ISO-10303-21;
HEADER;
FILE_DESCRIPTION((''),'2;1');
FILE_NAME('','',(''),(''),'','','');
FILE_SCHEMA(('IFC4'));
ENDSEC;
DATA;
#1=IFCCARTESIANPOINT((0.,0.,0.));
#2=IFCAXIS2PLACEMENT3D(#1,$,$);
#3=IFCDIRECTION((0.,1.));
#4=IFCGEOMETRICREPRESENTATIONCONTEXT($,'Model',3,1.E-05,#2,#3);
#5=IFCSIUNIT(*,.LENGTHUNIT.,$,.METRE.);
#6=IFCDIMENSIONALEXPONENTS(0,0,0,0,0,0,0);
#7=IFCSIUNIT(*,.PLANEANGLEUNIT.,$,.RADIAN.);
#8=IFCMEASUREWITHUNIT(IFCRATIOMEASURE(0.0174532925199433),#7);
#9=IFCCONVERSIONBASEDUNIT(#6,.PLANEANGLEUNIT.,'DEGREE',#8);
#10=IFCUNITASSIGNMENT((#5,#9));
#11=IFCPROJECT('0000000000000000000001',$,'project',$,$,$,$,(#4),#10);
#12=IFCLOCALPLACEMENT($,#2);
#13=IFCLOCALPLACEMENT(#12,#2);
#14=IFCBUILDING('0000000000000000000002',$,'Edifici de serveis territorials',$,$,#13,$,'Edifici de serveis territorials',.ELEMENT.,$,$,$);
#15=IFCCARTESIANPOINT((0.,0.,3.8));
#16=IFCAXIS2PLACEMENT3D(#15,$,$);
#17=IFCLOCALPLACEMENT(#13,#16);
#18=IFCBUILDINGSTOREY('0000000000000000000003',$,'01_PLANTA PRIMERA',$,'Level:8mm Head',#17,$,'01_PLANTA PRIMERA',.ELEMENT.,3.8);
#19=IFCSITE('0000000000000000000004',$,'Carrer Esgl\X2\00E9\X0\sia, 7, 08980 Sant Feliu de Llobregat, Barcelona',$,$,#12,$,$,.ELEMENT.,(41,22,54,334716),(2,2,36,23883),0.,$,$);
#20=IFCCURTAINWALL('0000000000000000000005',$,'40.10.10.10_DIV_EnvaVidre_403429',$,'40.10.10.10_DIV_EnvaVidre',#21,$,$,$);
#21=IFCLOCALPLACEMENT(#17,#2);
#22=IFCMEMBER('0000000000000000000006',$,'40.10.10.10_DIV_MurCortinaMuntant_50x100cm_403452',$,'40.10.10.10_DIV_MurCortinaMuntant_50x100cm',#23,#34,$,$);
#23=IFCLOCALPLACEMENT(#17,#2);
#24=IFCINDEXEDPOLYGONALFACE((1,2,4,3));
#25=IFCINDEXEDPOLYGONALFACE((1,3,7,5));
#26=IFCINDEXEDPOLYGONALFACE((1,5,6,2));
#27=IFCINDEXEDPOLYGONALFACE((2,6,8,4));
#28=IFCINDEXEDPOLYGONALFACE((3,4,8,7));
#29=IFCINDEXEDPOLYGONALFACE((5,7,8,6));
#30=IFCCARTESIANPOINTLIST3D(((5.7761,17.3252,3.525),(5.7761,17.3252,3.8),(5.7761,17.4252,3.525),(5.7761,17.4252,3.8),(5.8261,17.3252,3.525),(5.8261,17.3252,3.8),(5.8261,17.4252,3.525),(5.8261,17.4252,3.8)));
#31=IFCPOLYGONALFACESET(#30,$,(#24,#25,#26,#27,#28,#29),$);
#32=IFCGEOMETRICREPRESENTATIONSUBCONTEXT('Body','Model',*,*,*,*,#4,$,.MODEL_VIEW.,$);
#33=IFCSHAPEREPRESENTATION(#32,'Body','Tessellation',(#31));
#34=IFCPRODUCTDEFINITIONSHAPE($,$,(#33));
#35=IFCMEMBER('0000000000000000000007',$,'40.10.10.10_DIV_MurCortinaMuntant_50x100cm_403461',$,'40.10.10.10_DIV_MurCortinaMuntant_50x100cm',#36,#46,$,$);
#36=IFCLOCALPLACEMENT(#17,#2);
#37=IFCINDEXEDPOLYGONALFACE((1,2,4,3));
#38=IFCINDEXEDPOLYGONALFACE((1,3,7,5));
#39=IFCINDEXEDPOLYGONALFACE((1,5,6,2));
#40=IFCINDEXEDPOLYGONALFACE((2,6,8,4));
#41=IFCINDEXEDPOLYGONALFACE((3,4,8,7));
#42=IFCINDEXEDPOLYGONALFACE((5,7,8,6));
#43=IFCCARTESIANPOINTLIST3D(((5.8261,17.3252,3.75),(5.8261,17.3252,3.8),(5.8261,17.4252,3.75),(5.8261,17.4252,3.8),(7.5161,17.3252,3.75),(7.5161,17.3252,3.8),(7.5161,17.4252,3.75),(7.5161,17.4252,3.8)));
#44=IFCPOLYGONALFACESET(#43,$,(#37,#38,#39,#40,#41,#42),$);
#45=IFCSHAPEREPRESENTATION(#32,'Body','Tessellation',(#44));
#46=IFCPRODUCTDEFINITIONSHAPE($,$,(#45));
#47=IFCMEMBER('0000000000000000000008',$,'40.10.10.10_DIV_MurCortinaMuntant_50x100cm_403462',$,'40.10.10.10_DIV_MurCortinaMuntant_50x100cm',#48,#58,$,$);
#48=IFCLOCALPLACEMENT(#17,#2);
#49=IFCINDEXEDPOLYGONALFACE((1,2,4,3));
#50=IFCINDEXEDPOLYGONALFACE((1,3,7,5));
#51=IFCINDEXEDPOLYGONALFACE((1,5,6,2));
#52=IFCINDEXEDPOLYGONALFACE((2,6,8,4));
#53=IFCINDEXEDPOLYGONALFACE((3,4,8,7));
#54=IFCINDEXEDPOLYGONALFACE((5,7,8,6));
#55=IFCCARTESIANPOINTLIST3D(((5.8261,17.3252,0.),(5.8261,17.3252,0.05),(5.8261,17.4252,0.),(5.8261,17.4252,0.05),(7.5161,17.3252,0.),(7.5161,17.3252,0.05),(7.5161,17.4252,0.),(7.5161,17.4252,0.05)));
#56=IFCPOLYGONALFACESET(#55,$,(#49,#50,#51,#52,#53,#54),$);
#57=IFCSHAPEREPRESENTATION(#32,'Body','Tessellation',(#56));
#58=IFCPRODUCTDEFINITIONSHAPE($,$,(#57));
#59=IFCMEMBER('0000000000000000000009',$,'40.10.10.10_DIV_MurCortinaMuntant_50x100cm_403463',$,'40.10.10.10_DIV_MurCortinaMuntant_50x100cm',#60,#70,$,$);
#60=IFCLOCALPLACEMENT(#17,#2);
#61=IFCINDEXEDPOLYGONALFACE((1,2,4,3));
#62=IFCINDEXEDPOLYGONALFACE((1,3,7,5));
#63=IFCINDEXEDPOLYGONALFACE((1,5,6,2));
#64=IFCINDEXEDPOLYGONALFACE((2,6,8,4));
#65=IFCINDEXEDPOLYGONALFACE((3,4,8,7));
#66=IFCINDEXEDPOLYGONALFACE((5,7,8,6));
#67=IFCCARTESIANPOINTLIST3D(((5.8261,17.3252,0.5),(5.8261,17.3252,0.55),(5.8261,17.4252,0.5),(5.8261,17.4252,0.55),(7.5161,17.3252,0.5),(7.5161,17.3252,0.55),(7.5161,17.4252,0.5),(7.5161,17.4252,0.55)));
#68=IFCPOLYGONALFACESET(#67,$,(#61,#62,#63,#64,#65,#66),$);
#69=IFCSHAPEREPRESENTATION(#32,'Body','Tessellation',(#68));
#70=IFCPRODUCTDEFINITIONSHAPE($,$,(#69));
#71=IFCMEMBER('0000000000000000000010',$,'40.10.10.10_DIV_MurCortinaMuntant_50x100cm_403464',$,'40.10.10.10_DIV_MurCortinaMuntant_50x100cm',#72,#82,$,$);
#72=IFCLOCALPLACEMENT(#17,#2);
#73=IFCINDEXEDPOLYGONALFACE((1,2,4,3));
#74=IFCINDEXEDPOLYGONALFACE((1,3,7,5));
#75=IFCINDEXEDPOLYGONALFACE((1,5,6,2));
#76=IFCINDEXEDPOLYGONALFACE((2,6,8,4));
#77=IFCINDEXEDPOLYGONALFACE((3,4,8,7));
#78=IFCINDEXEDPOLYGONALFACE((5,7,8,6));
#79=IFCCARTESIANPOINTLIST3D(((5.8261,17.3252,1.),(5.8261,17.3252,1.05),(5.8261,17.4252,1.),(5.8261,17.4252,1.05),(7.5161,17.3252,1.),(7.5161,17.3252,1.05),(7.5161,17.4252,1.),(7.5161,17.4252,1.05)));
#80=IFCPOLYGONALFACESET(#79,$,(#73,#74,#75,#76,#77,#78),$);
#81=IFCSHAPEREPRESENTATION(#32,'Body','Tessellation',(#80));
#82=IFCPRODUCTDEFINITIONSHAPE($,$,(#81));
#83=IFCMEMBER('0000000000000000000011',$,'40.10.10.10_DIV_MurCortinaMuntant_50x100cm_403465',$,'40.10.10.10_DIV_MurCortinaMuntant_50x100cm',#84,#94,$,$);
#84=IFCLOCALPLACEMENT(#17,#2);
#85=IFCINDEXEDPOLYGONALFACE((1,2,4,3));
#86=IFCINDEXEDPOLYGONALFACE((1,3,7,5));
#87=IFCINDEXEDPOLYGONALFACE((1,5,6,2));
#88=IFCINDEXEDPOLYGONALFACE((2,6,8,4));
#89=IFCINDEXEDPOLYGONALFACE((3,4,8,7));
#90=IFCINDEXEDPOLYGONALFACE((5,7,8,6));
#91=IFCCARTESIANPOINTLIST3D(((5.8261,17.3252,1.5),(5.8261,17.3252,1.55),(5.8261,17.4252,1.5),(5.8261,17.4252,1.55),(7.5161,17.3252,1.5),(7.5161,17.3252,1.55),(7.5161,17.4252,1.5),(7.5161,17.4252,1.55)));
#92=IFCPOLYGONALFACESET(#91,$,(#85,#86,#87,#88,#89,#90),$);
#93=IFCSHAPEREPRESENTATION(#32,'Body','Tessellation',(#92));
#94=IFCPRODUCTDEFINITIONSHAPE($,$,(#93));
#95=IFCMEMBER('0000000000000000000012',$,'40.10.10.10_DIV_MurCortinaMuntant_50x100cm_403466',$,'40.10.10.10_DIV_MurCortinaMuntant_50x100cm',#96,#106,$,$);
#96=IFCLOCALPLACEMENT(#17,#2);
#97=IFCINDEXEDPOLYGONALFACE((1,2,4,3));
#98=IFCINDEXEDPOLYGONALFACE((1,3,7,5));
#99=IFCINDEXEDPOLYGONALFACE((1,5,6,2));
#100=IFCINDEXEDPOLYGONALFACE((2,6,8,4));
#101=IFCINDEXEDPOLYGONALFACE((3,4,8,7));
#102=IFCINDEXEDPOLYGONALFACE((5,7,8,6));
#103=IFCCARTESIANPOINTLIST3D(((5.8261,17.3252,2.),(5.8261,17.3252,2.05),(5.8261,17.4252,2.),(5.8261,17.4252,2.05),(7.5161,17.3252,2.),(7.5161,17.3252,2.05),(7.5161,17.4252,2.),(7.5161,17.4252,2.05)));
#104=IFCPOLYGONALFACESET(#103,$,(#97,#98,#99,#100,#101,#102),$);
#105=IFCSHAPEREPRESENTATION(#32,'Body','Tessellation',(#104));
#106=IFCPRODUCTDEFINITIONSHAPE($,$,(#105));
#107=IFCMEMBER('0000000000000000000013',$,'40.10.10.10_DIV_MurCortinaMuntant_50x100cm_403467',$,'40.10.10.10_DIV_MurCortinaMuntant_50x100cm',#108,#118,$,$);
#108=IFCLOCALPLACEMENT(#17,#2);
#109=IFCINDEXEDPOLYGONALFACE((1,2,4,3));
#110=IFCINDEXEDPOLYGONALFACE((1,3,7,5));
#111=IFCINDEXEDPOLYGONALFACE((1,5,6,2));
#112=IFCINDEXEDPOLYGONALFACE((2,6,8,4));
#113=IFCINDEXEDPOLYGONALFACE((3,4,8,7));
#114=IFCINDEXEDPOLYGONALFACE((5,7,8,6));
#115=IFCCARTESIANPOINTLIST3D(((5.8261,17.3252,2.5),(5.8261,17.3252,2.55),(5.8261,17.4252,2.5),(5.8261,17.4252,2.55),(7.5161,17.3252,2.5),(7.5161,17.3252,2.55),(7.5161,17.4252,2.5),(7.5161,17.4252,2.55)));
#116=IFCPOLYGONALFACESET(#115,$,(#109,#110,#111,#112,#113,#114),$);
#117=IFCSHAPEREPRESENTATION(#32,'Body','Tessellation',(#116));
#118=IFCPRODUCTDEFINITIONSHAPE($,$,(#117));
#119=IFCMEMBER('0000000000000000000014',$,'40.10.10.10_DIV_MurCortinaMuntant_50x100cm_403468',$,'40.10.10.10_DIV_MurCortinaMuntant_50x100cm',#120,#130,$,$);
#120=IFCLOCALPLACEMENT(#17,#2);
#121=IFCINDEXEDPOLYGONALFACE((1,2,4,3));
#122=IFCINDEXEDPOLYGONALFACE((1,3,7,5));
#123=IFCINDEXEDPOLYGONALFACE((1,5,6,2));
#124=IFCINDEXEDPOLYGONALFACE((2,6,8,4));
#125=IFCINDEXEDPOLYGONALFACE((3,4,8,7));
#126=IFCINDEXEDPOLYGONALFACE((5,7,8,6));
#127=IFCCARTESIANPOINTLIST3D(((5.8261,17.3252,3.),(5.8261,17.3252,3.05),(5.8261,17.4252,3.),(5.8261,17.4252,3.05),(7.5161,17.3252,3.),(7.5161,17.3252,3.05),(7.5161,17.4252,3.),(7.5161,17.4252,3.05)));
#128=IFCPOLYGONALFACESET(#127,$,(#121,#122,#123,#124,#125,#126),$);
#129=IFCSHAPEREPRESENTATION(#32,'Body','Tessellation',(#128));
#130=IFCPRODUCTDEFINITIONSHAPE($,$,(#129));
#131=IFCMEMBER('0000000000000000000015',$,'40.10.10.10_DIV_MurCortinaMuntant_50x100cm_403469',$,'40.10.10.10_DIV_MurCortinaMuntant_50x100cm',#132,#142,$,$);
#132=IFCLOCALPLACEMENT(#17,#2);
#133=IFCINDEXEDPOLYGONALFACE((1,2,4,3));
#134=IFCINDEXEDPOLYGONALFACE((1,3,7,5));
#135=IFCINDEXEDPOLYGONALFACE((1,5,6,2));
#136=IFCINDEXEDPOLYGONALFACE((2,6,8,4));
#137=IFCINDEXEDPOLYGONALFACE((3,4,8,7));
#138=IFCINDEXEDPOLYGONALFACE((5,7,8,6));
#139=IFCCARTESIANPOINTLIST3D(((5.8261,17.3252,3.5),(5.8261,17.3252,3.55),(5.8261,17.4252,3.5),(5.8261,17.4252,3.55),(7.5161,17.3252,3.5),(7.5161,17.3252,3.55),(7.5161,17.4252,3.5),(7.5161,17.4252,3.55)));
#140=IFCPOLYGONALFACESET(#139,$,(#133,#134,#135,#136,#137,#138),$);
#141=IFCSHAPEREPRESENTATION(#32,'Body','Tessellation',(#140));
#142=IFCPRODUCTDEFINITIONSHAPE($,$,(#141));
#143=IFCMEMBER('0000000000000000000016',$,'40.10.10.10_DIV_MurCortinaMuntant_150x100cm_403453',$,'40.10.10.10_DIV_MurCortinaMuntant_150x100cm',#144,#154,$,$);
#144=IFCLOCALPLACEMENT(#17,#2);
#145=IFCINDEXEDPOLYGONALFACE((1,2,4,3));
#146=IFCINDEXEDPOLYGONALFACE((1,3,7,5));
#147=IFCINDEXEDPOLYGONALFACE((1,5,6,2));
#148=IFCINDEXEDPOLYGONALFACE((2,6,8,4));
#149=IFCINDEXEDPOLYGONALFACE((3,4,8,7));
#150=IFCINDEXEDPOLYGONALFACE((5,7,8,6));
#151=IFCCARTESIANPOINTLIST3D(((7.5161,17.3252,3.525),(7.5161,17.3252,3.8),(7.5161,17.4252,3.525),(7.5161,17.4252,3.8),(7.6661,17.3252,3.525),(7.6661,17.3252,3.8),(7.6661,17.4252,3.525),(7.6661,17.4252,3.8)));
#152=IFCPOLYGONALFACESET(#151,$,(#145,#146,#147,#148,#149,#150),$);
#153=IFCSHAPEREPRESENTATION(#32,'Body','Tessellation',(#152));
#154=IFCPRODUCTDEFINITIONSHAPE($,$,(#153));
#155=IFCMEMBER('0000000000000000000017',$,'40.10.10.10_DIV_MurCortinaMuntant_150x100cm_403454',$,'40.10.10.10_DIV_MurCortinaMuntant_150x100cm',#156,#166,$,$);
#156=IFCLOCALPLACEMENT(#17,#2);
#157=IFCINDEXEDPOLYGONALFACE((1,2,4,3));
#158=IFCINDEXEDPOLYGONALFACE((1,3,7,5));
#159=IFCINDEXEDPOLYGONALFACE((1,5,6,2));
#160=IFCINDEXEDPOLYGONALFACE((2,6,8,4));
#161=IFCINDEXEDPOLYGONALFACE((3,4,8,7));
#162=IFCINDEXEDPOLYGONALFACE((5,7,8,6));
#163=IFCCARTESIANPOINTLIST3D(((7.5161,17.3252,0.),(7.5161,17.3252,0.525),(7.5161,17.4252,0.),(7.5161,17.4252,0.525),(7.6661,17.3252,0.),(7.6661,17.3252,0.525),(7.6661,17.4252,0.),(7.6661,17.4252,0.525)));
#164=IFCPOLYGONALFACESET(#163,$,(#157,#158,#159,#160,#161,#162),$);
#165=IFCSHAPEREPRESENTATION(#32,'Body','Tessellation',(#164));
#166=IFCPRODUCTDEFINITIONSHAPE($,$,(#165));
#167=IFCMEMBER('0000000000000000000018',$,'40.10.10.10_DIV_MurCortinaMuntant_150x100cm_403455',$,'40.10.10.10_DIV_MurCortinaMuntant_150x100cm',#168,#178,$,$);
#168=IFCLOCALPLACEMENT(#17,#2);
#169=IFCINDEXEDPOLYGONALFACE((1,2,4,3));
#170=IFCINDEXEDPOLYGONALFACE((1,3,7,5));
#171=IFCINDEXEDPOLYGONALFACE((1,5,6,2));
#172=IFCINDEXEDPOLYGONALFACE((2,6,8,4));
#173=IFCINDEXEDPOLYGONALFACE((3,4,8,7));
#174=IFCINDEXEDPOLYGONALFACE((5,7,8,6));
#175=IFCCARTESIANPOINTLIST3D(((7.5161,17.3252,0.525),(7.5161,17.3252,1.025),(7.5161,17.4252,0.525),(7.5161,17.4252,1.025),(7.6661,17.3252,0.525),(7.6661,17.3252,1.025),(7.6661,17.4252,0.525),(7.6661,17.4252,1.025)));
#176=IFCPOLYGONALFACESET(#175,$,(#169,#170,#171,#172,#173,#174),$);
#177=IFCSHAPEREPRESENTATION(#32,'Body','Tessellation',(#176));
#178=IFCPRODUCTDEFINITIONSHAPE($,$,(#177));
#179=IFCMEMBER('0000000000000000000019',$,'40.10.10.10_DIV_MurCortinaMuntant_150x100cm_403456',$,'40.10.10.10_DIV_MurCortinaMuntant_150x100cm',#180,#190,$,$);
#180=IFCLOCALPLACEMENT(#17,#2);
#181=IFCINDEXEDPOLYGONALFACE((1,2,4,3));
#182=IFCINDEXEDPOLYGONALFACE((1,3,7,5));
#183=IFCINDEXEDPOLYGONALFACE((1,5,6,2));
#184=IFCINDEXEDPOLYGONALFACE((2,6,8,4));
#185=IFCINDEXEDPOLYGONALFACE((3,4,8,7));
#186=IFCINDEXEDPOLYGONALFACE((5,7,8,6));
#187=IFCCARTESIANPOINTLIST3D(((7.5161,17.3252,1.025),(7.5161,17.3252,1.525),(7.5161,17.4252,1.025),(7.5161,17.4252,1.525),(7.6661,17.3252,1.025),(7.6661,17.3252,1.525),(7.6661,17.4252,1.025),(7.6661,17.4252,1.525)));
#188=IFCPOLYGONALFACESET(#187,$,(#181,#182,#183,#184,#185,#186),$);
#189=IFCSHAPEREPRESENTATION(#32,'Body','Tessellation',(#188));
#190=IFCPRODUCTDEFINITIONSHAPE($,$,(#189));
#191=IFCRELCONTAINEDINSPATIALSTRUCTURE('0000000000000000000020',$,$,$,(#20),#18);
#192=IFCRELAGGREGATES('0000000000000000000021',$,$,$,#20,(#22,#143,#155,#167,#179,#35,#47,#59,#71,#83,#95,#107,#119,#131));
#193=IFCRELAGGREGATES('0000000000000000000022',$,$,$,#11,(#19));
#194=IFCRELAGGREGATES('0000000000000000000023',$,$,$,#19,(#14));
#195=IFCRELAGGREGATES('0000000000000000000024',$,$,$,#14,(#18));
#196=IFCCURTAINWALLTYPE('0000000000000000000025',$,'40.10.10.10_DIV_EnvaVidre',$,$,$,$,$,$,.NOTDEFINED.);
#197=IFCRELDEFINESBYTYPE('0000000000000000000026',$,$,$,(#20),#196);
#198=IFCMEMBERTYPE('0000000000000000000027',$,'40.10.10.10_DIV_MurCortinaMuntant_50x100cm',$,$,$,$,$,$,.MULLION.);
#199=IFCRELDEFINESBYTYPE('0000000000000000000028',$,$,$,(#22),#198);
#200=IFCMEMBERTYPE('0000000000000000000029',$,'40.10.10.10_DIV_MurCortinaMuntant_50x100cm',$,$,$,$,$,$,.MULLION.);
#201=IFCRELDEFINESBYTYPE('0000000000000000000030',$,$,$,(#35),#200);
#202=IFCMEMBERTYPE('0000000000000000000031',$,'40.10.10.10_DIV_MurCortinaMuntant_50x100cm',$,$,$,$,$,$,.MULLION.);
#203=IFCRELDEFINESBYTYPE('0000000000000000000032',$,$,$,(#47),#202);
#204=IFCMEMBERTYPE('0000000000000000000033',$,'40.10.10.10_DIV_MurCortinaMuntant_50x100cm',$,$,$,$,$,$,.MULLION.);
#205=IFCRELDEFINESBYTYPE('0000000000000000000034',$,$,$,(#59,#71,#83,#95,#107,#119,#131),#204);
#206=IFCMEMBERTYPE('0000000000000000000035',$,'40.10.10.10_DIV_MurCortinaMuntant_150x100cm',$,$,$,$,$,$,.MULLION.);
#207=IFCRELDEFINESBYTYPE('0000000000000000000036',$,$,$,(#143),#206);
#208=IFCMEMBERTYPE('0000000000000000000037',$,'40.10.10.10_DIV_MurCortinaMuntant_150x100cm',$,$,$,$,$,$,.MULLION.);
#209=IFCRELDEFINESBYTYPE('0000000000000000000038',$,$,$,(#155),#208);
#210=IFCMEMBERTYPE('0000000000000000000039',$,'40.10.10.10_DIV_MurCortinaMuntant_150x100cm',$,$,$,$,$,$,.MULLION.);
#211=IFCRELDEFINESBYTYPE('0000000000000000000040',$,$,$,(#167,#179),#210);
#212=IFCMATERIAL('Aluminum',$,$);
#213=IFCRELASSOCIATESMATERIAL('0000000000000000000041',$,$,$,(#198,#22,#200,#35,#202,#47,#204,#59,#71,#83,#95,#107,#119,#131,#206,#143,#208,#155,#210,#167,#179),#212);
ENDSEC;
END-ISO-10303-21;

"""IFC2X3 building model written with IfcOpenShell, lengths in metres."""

from ifc_helpers import new_model, entity, si_unit, converted_unit, direction, frame, origin, origin_2d_with_axis, place, context, subcontext, project, spatial, rectangle, extrude, source, transform, mapped, material, type_object, type_shapes, element, aggregate, save


model = new_model("IFC2X3")

# Units and contexts
model_context = context("Model", 3, precision=1e-05, world=origin(), true_north=direction((0.0, 1.0)))
body_context = subcontext(model_context, "Body", "Model", "MODEL_VIEW")
ifc_project = project(units=[si_unit("LENGTHUNIT", "METRE"), converted_unit("PLANEANGLEUNIT", "DEGREE", entity("IfcRatioMeasure", 0.0174532925199433), si_unit("PLANEANGLEUNIT", "RADIAN"), dimensions=[0, 0, 0, 0, 0, 0, 0])], contexts=[model_context])

# Site, building, storey
site_placement = place(None, origin())
site = spatial("IfcSite", under=ifc_project, at=site_placement, Name="Carrer Església, 7, 08980 Sant Feliu de Llobregat, Barcelona", CompositionType="ELEMENT", RefLatitude=(41, 22, 54, 334716), RefLongitude=(2, 2, 36, 23883), RefElevation=0.0)
building_placement = place(site_placement, origin())
building = spatial("IfcBuilding", under=site, at=building_placement, Name="Edifici de serveis territorials", LongName="Edifici de serveis territorials", CompositionType="ELEMENT")
storey_placement = place(building_placement, frame((0.0, 0.0, 3.8)))
storey = spatial("IfcBuildingStorey", under=building, at=storey_placement, Name="01_PLANTA PRIMERA", ObjectType="Level:8mm Head", LongName="01_PLANTA PRIMERA", CompositionType="ELEMENT", Elevation=3.8)

# Curtain wall
curtain_wall_type = type_object("IfcCurtainWallType", Name="40.10.10.10_DIV_EnvaVidre", PredefinedType="NOTDEFINED")
ifc_material_1 = material(Name="Aluminum")
curtain_wall_1_placement = place(storey_placement, frame((0.0, 0.0, -3.8)))
curtain_wall_1 = element("IfcCurtainWall", 1, at=curtain_wall_1_placement, inside=storey, type_object=curtain_wall_type, Name="40.10.10.10_DIV_EnvaVidre_403429", ObjectType="40.10.10.10_DIV_EnvaVidre")

# Members
member_type_1 = type_object("IfcMemberType", Name="40.10.10.10_DIV_MurCortinaMuntant_50x100cm", PredefinedType="MULLION", material=ifc_material_1)
shared_shape_1 = source(origin(), body_context, "Body", "SweptSolid", [
    extrude(rectangle(XDim=0.1, YDim=0.05, at=origin_2d_with_axis()), frame((-0.025, 0.0, -0.275), z_axis=(0.0, 0.0, 1.0), x_axis=(0.0, -1.0, 0.0)), (0.0, 0.0, 1.0), 0.275),
])
type_shapes(member_type_1, [shared_shape_1])
member_1_placement = place(storey_placement, frame((5.7761, 17.3752, 3.525), z_axis=(0.0, 0.0, -1.0), x_axis=(-1.0, 0.0, 0.0)))
member_1 = element("IfcMember", 2, at=member_1_placement, type_object=member_type_1, material=ifc_material_1, Name="40.10.10.10_DIV_MurCortinaMuntant_50x100cm_403452", ObjectType="40.10.10.10_DIV_MurCortinaMuntant_50x100cm", context=body_context, shape_type="MappedRepresentation", body=[
    mapped(shared_shape_1, transform((0.0, 0.0, 0.0), scale=1.0)),
])
member_type_2 = type_object("IfcMemberType", Name="40.10.10.10_DIV_MurCortinaMuntant_50x100cm", PredefinedType="MULLION", material=ifc_material_1)
shared_shape_2 = source(origin(), body_context, "Body", "SweptSolid", [
    extrude(rectangle(XDim=0.1, YDim=0.05, at=origin_2d_with_axis()), frame((-0.025, 0.0, -1.69), z_axis=(0.0, 0.0, 1.0), x_axis=(0.0, -1.0, 0.0)), (0.0, 0.0, 1.0), 1.69),
])
type_shapes(member_type_2, [shared_shape_2])
member_2_placement = place(storey_placement, frame((5.8261, 17.3752, 3.8), z_axis=(-1.0, 0.0, 0.0), x_axis=(0.0, 0.0, 1.0)))
member_2 = element("IfcMember", 3, at=member_2_placement, type_object=member_type_2, material=ifc_material_1, Name="40.10.10.10_DIV_MurCortinaMuntant_50x100cm_403461", ObjectType="40.10.10.10_DIV_MurCortinaMuntant_50x100cm", context=body_context, shape_type="MappedRepresentation", body=[
    mapped(shared_shape_2, transform((0.0, 0.0, 0.0), scale=1.0)),
])
member_type_3 = type_object("IfcMemberType", Name="40.10.10.10_DIV_MurCortinaMuntant_50x100cm", PredefinedType="MULLION", material=ifc_material_1)
shared_shape_3 = source(origin(), body_context, "Body", "SweptSolid", [
    extrude(rectangle(XDim=0.1, YDim=0.05, at=origin_2d_with_axis()), frame((-0.025, 0.0, -1.69), z_axis=(0.0, 0.0, 1.0), x_axis=(0.0, -1.0, 0.0)), (0.0, 0.0, 1.0), 1.69),
])
type_shapes(member_type_3, [shared_shape_3])
member_3_placement = place(storey_placement, frame((7.5161, 17.3752, 0.0), z_axis=(1.0, 0.0, 0.0), x_axis=(0.0, 0.0, -1.0)))
member_3 = element("IfcMember", 4, at=member_3_placement, type_object=member_type_3, material=ifc_material_1, Name="40.10.10.10_DIV_MurCortinaMuntant_50x100cm_403462", ObjectType="40.10.10.10_DIV_MurCortinaMuntant_50x100cm", context=body_context, shape_type="MappedRepresentation", body=[
    mapped(shared_shape_3, transform((0.0, 0.0, 0.0), scale=1.0)),
])
member_type_4 = type_object("IfcMemberType", Name="40.10.10.10_DIV_MurCortinaMuntant_50x100cm", PredefinedType="MULLION", material=ifc_material_1)
shared_shape_4 = source(origin(), body_context, "Body", "SweptSolid", [
    extrude(rectangle(XDim=0.1, YDim=0.05, at=origin_2d_with_axis()), frame((0.0, 0.0, -1.69), z_axis=(0.0, 0.0, 1.0), x_axis=(0.0, -1.0, 0.0)), (0.0, 0.0, 1.0), 1.69),
])
type_shapes(member_type_4, [shared_shape_4])
member_4_placement = place(storey_placement, frame((5.8261, 17.3752, 0.525), z_axis=(-1.0, 0.0, 0.0), x_axis=(0.0, 0.0, 1.0)))
member_4 = element("IfcMember", 5, at=member_4_placement, type_object=member_type_4, material=ifc_material_1, Name="40.10.10.10_DIV_MurCortinaMuntant_50x100cm_403463", ObjectType="40.10.10.10_DIV_MurCortinaMuntant_50x100cm", context=body_context, shape_type="MappedRepresentation", body=[
    mapped(shared_shape_4, transform((0.0, 0.0, 0.0), scale=1.0)),
])
member_5_placement = place(storey_placement, frame((5.8261, 17.3752, 1.025), z_axis=(-1.0, 0.0, 0.0), x_axis=(0.0, 0.0, 1.0)))
member_5 = element("IfcMember", 6, at=member_5_placement, type_object=member_type_4, material=ifc_material_1, Name="40.10.10.10_DIV_MurCortinaMuntant_50x100cm_403464", ObjectType="40.10.10.10_DIV_MurCortinaMuntant_50x100cm", context=body_context, shape_type="MappedRepresentation", body=[
    mapped(shared_shape_4, transform((0.0, 0.0, 0.0), scale=1.0)),
])
member_6_placement = place(storey_placement, frame((5.8261, 17.3752, 1.525), z_axis=(-1.0, 0.0, 0.0), x_axis=(0.0, 0.0, 1.0)))
member_6 = element("IfcMember", 7, at=member_6_placement, type_object=member_type_4, material=ifc_material_1, Name="40.10.10.10_DIV_MurCortinaMuntant_50x100cm_403465", ObjectType="40.10.10.10_DIV_MurCortinaMuntant_50x100cm", context=body_context, shape_type="MappedRepresentation", body=[
    mapped(shared_shape_4, transform((0.0, 0.0, 0.0), scale=1.0)),
])
member_7_placement = place(storey_placement, frame((5.8261, 17.3752, 2.025), z_axis=(-1.0, 0.0, 0.0), x_axis=(0.0, 0.0, 1.0)))
member_7 = element("IfcMember", 8, at=member_7_placement, type_object=member_type_4, material=ifc_material_1, Name="40.10.10.10_DIV_MurCortinaMuntant_50x100cm_403466", ObjectType="40.10.10.10_DIV_MurCortinaMuntant_50x100cm", context=body_context, shape_type="MappedRepresentation", body=[
    mapped(shared_shape_4, transform((0.0, 0.0, 0.0), scale=1.0)),
])
member_8_placement = place(storey_placement, frame((5.8261, 17.3752, 2.525), z_axis=(-1.0, 0.0, 0.0), x_axis=(0.0, 0.0, 1.0)))
member_8 = element("IfcMember", 9, at=member_8_placement, type_object=member_type_4, material=ifc_material_1, Name="40.10.10.10_DIV_MurCortinaMuntant_50x100cm_403467", ObjectType="40.10.10.10_DIV_MurCortinaMuntant_50x100cm", context=body_context, shape_type="MappedRepresentation", body=[
    mapped(shared_shape_4, transform((0.0, 0.0, 0.0), scale=1.0)),
])
member_9_placement = place(storey_placement, frame((5.8261, 17.3752, 3.025), z_axis=(-1.0, 0.0, 0.0), x_axis=(0.0, 0.0, 1.0)))
member_9 = element("IfcMember", 10, at=member_9_placement, type_object=member_type_4, material=ifc_material_1, Name="40.10.10.10_DIV_MurCortinaMuntant_50x100cm_403468", ObjectType="40.10.10.10_DIV_MurCortinaMuntant_50x100cm", context=body_context, shape_type="MappedRepresentation", body=[
    mapped(shared_shape_4, transform((0.0, 0.0, 0.0), scale=1.0)),
])
member_10_placement = place(storey_placement, frame((5.8261, 17.3752, 3.525), z_axis=(-1.0, 0.0, 0.0), x_axis=(0.0, 0.0, 1.0)))
member_10 = element("IfcMember", 11, at=member_10_placement, type_object=member_type_4, material=ifc_material_1, Name="40.10.10.10_DIV_MurCortinaMuntant_50x100cm_403469", ObjectType="40.10.10.10_DIV_MurCortinaMuntant_50x100cm", context=body_context, shape_type="MappedRepresentation", body=[
    mapped(shared_shape_4, transform((0.0, 0.0, 0.0), scale=1.0)),
])
member_type_5 = type_object("IfcMemberType", Name="40.10.10.10_DIV_MurCortinaMuntant_150x100cm", PredefinedType="MULLION", material=ifc_material_1)
shared_shape_5 = source(origin(), body_context, "Body", "SweptSolid", [
    extrude(rectangle(XDim=0.1, YDim=0.15, at=origin_2d_with_axis()), frame((-0.075, 0.0, -0.275), z_axis=(0.0, 0.0, 1.0), x_axis=(0.0, -1.0, 0.0)), (0.0, 0.0, 1.0), 0.275),
])
type_shapes(member_type_5, [shared_shape_5])
member_11_placement = place(storey_placement, frame((7.6661, 17.3752, 3.8)))
member_11 = element("IfcMember", 12, at=member_11_placement, type_object=member_type_5, material=ifc_material_1, Name="40.10.10.10_DIV_MurCortinaMuntant_150x100cm_403453", ObjectType="40.10.10.10_DIV_MurCortinaMuntant_150x100cm", context=body_context, shape_type="MappedRepresentation", body=[
    mapped(shared_shape_5, transform((0.0, 0.0, 0.0), scale=1.0)),
])
member_type_6 = type_object("IfcMemberType", Name="40.10.10.10_DIV_MurCortinaMuntant_150x100cm", PredefinedType="MULLION", material=ifc_material_1)
shared_shape_6 = source(origin(), body_context, "Body", "SweptSolid", [
    extrude(rectangle(XDim=0.1, YDim=0.15, at=origin_2d_with_axis()), frame((-0.075, 0.0, -0.525), z_axis=(0.0, 0.0, 1.0), x_axis=(0.0, -1.0, 0.0)), (0.0, 0.0, 1.0), 0.525),
])
type_shapes(member_type_6, [shared_shape_6])
member_12_placement = place(storey_placement, frame((7.6661, 17.3752, 0.525)))
member_12 = element("IfcMember", 13, at=member_12_placement, type_object=member_type_6, material=ifc_material_1, Name="40.10.10.10_DIV_MurCortinaMuntant_150x100cm_403454", ObjectType="40.10.10.10_DIV_MurCortinaMuntant_150x100cm", context=body_context, shape_type="MappedRepresentation", body=[
    mapped(shared_shape_6, transform((0.0, 0.0, 0.0), scale=1.0)),
])
member_type_7 = type_object("IfcMemberType", Name="40.10.10.10_DIV_MurCortinaMuntant_150x100cm", PredefinedType="MULLION", material=ifc_material_1)
shared_shape_7 = source(origin(), body_context, "Body", "SweptSolid", [
    extrude(rectangle(XDim=0.1, YDim=0.15, at=origin_2d_with_axis()), frame((-0.075, 0.0, -0.5), z_axis=(0.0, 0.0, 1.0), x_axis=(0.0, -1.0, 0.0)), (0.0, 0.0, 1.0), 0.5),
])
type_shapes(member_type_7, [shared_shape_7])
member_13_placement = place(storey_placement, frame((7.6661, 17.3752, 1.025)))
member_13 = element("IfcMember", 14, at=member_13_placement, type_object=member_type_7, material=ifc_material_1, Name="40.10.10.10_DIV_MurCortinaMuntant_150x100cm_403455", ObjectType="40.10.10.10_DIV_MurCortinaMuntant_150x100cm", context=body_context, shape_type="MappedRepresentation", body=[
    mapped(shared_shape_7, transform((0.0, 0.0, 0.0), scale=1.0)),
])
member_14_placement = place(storey_placement, frame((7.6661, 17.3752, 1.525)))
member_14 = element("IfcMember", 15, at=member_14_placement, type_object=member_type_7, material=ifc_material_1, Name="40.10.10.10_DIV_MurCortinaMuntant_150x100cm_403456", ObjectType="40.10.10.10_DIV_MurCortinaMuntant_150x100cm", context=body_context, shape_type="MappedRepresentation", body=[
    mapped(shared_shape_7, transform((0.0, 0.0, 0.0), scale=1.0)),
])

aggregate(curtain_wall_1, [member_1, member_11, member_12, member_13, member_14, member_2, member_3, member_4, member_5, member_6, member_7, member_8, member_9, member_10])

save(model, "model.ifc")
